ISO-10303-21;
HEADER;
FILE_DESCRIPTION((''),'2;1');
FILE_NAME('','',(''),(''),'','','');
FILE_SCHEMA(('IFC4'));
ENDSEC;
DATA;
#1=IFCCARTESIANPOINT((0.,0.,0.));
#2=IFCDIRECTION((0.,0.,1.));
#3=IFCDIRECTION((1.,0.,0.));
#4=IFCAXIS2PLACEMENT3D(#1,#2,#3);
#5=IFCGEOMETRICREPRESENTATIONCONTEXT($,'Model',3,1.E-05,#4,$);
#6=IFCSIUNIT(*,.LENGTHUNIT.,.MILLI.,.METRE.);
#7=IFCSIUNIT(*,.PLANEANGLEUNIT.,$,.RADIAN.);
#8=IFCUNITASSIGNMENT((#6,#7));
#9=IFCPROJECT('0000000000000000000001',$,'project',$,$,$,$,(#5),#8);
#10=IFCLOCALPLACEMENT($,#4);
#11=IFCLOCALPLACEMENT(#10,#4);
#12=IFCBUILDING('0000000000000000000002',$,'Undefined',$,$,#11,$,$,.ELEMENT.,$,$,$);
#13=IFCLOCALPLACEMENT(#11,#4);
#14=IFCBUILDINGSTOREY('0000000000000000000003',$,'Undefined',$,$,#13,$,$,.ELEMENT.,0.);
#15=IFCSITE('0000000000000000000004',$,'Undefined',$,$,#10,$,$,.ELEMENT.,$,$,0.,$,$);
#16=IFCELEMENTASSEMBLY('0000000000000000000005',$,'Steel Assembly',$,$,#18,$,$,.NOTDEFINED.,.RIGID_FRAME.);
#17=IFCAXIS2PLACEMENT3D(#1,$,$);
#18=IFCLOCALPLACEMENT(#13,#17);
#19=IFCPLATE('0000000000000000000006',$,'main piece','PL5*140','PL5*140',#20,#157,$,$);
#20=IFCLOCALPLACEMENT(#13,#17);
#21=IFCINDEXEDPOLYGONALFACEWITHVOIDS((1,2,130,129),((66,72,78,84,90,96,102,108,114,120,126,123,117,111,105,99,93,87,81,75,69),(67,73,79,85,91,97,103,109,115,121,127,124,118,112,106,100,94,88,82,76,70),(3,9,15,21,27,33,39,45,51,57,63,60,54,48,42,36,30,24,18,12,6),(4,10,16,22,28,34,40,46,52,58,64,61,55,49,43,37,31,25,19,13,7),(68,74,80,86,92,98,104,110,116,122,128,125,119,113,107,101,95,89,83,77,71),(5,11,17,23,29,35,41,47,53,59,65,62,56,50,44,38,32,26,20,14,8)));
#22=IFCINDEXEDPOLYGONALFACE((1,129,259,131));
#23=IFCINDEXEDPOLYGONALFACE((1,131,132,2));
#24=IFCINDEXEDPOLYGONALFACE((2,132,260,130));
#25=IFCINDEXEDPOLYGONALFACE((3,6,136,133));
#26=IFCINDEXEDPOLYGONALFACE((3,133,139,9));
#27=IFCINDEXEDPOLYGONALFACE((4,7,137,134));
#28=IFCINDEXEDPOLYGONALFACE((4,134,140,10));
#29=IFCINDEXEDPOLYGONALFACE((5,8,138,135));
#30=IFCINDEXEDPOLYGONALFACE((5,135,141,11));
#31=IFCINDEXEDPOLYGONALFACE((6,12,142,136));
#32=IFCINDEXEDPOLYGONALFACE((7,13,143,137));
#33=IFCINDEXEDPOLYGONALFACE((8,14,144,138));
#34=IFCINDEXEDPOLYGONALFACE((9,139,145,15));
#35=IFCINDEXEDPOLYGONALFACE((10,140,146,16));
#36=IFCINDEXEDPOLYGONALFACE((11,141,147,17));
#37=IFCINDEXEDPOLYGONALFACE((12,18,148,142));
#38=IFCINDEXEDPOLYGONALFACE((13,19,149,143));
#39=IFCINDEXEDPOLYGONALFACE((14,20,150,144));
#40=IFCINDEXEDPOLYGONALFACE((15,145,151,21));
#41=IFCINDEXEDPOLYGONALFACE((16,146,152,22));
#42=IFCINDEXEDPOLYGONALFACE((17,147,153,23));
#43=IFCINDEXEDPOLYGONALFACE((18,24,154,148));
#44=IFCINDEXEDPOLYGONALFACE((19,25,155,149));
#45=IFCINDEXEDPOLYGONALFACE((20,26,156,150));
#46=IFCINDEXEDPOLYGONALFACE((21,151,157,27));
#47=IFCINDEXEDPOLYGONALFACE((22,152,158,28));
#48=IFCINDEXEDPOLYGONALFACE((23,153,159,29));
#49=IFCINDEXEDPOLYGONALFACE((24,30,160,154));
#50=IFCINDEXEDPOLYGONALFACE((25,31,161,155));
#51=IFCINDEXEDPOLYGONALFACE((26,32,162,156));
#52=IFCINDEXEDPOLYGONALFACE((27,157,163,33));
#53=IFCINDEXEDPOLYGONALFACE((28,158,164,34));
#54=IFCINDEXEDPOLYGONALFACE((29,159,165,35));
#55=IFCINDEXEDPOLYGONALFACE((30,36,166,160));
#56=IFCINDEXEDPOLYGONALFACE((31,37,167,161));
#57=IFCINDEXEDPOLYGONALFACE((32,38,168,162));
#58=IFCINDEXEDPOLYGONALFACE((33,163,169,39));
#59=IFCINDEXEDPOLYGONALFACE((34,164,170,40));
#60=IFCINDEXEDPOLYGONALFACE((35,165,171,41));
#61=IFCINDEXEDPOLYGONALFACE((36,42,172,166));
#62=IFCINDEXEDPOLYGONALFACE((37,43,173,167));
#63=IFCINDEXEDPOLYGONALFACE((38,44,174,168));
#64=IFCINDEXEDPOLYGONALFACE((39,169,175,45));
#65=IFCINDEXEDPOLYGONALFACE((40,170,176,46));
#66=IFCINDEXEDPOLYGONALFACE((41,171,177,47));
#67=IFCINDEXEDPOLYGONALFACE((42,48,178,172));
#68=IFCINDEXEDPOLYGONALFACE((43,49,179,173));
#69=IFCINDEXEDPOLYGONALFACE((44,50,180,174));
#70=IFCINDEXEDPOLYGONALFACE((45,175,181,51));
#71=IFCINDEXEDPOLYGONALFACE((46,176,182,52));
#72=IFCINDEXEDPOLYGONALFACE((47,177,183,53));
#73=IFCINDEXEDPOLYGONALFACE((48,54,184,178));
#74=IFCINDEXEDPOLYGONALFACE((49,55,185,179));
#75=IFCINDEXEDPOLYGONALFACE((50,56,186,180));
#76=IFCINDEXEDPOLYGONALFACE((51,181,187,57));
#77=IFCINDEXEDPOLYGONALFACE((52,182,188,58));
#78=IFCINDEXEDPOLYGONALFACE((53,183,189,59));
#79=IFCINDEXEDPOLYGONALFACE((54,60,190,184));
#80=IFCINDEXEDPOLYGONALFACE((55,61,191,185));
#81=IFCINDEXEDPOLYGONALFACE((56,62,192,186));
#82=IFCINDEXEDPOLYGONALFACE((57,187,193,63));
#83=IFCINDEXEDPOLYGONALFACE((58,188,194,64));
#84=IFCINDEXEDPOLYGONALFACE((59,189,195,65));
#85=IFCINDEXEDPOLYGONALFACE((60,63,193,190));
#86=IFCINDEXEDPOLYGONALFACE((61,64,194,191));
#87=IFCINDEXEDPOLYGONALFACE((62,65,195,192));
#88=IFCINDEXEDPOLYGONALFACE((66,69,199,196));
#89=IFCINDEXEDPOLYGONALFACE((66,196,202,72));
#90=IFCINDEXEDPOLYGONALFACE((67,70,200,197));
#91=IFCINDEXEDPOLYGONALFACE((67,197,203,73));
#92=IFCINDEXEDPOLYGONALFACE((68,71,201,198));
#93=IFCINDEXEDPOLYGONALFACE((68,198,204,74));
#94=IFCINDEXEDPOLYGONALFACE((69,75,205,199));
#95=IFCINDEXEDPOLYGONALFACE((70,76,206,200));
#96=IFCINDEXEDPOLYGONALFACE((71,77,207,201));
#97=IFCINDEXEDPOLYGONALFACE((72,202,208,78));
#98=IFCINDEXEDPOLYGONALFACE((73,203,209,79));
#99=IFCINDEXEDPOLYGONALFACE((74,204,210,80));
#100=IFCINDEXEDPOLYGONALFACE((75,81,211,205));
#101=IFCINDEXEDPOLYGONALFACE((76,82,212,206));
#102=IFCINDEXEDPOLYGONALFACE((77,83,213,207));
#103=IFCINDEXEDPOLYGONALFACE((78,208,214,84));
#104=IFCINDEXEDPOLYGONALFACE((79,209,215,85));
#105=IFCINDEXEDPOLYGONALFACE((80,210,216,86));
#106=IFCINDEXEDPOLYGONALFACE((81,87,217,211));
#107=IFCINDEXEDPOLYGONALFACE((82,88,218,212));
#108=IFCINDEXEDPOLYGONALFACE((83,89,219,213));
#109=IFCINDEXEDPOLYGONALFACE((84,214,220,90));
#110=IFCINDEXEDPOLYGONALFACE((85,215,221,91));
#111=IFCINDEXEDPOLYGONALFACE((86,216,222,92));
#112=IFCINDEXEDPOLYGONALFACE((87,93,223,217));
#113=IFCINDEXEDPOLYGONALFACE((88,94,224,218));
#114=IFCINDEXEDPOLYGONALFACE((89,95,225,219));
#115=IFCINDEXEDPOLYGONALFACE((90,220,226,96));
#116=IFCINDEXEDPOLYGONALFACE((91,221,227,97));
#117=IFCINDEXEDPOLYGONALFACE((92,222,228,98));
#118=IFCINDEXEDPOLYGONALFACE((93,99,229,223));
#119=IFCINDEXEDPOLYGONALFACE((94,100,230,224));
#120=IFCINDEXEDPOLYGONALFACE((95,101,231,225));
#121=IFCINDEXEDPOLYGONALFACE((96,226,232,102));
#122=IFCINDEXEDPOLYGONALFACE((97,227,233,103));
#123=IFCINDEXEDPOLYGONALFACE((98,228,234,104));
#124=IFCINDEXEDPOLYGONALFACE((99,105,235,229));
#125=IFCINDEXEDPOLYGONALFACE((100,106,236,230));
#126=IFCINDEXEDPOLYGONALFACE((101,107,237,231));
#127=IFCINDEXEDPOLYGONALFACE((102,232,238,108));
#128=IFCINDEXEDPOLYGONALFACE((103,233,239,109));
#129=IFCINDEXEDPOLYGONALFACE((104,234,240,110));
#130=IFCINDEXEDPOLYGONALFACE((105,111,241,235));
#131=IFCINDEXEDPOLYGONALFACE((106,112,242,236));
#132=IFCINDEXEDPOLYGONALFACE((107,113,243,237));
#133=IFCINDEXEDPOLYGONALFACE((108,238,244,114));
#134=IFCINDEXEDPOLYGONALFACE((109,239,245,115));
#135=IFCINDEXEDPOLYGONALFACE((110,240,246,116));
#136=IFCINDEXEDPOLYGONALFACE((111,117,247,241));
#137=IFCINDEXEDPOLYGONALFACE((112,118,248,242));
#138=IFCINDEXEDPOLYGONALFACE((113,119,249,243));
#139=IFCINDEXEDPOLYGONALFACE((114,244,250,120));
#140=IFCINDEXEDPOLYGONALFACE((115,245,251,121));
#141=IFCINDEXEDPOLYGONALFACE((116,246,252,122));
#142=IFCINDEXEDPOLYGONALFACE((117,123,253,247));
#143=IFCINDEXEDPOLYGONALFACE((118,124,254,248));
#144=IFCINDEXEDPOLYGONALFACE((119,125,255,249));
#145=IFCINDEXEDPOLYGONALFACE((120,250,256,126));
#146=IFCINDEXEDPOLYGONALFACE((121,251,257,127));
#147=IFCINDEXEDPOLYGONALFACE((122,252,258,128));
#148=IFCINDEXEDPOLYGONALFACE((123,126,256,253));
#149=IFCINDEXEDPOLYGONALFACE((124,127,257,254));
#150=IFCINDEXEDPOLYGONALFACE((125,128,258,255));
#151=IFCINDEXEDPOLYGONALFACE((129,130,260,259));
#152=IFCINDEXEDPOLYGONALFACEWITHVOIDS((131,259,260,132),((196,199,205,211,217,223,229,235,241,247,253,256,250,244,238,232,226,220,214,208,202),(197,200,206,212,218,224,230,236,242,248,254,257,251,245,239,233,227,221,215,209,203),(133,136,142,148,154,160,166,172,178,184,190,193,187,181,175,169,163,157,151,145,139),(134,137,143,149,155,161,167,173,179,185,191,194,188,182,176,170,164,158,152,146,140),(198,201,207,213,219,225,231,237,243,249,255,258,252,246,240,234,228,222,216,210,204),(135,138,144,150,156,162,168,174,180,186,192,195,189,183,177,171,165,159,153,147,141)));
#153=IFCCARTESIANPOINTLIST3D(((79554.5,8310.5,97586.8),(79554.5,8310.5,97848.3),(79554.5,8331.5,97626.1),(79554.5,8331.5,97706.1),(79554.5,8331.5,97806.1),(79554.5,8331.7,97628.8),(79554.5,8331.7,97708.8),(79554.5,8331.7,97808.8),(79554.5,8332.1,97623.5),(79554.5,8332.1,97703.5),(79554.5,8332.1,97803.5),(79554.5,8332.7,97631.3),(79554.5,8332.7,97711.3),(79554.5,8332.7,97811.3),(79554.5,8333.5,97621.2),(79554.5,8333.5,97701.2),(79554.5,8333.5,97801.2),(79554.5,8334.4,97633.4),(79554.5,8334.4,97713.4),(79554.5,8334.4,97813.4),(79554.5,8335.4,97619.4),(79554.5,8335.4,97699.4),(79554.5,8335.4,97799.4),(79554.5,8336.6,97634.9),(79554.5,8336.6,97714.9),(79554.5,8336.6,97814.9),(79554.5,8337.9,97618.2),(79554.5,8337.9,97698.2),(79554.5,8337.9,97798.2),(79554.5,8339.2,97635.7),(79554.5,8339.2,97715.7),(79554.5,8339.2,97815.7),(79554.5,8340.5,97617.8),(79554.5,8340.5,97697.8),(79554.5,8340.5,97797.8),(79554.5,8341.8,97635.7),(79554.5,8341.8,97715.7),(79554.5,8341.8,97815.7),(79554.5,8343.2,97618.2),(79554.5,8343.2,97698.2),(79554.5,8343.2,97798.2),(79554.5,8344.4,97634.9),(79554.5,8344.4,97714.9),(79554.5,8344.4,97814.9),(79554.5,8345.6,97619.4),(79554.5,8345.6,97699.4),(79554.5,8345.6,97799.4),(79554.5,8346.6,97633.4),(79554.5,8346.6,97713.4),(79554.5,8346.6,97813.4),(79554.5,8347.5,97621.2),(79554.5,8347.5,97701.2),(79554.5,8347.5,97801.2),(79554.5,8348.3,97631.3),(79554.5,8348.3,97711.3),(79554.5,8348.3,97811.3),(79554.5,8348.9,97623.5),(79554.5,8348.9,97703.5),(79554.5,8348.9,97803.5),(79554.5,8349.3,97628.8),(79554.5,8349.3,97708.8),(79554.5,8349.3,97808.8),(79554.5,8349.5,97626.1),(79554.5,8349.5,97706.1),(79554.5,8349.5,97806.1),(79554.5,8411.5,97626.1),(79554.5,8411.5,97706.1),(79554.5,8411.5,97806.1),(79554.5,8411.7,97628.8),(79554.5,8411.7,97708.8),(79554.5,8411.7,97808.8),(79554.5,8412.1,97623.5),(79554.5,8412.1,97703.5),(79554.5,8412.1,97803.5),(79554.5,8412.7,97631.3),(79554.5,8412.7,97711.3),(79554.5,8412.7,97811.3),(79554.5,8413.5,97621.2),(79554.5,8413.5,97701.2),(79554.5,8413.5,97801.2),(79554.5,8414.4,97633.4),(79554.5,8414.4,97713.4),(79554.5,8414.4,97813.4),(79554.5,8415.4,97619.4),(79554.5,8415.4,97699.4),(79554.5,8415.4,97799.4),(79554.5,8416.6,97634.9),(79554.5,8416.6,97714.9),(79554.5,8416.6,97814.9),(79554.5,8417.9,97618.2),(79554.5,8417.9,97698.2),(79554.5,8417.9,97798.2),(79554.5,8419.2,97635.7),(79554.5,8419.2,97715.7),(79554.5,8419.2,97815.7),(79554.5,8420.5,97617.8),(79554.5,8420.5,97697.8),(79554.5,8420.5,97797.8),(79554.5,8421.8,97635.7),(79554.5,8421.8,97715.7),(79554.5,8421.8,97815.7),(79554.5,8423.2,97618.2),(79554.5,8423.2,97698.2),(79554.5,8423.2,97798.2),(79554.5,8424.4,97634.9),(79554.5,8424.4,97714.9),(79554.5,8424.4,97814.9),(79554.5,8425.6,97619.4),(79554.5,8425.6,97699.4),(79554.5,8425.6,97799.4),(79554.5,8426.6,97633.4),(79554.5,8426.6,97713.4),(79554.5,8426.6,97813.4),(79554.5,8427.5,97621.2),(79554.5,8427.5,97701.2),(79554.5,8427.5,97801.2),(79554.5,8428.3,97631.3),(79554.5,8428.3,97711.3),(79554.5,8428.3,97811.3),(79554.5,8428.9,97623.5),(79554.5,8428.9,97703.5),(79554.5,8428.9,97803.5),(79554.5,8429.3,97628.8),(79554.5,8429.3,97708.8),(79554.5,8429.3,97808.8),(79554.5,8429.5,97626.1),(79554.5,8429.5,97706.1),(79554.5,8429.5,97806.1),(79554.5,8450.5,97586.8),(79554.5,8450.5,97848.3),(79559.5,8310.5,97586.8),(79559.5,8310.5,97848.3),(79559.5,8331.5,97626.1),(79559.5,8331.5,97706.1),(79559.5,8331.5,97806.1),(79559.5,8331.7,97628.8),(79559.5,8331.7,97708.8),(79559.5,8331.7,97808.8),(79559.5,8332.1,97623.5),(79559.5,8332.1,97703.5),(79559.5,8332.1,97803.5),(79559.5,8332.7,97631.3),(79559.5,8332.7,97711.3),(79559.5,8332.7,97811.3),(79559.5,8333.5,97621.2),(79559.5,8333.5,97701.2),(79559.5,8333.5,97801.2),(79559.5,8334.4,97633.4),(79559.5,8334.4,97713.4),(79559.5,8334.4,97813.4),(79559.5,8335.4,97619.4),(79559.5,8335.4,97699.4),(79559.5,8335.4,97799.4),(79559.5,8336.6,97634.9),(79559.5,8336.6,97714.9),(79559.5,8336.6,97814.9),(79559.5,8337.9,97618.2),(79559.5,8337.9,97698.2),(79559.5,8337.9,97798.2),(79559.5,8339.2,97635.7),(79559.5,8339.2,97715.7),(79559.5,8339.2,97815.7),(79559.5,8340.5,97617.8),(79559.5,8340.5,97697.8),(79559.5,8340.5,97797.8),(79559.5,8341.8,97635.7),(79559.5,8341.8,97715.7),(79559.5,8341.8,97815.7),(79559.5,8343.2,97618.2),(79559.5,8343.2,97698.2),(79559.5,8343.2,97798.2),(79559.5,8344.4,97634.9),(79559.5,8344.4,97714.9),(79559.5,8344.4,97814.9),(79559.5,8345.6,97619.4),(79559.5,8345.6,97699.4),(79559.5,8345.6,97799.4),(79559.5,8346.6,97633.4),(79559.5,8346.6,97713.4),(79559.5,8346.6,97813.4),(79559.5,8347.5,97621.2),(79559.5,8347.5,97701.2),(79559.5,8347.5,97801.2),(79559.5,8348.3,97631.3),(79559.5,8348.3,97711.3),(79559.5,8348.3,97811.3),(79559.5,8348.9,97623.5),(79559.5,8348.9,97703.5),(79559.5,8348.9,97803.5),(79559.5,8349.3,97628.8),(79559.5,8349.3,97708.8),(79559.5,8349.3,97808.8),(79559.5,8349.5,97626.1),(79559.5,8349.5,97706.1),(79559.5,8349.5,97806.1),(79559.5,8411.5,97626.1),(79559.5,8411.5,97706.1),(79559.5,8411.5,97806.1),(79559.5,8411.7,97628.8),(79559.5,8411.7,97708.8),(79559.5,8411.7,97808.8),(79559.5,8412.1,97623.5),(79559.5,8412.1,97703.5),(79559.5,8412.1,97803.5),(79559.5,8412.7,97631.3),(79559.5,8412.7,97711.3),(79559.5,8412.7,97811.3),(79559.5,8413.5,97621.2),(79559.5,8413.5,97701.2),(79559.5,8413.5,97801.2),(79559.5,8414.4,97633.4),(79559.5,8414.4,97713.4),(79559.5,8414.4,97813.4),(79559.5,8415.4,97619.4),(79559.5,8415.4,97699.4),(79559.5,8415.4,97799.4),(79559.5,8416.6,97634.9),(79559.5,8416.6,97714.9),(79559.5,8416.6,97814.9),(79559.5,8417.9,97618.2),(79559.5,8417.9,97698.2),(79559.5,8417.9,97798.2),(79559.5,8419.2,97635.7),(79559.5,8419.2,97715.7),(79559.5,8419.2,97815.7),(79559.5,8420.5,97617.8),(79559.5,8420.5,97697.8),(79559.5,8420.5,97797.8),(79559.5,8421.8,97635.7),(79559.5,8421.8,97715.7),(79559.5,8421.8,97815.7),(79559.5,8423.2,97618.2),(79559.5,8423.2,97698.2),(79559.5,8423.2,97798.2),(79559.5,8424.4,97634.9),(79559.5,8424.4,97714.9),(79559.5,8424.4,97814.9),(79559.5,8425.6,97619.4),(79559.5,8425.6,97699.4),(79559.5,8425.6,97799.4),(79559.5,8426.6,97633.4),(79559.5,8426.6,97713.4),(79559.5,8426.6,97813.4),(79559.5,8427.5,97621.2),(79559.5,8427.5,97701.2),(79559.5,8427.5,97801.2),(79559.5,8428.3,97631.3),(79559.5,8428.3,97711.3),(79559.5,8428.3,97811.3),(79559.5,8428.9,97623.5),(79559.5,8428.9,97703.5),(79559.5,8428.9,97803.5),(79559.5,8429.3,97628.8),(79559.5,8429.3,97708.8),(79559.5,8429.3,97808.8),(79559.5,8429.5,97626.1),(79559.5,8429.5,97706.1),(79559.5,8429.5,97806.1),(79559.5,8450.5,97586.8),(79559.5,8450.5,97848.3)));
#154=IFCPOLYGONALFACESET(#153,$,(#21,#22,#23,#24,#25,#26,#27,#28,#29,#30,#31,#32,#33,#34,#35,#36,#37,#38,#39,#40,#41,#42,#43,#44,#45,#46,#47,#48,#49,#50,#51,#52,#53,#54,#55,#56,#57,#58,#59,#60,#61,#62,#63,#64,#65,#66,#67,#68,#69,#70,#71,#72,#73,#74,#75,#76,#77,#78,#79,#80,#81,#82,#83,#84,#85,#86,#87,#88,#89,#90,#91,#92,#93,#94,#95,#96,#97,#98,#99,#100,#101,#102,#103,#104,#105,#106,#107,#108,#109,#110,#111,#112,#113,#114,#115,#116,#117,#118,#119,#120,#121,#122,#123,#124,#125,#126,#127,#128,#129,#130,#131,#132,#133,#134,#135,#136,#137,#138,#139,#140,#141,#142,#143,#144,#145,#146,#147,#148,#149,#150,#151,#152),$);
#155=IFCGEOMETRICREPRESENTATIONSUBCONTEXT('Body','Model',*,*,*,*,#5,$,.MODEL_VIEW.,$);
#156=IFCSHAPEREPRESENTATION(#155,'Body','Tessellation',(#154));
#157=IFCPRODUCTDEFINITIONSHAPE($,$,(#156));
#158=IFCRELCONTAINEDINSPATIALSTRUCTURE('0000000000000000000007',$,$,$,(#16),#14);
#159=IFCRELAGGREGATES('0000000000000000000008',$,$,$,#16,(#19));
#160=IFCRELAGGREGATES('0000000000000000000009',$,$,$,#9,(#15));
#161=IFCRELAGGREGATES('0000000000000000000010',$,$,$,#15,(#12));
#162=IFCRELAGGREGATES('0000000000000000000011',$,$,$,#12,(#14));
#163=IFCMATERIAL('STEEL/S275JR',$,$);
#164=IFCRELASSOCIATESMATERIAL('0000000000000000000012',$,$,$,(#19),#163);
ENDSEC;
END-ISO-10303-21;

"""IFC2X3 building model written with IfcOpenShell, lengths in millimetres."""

from ifc_helpers import new_model, si_unit, frame, origin_with_axes, origin_2d_with_axis, place, context, subcontext, project, spatial, polyline, circle, outline, extrude, source, transform, mapped, material, element, aggregate, save


model = new_model("IFC2X3")

# Units and contexts
model_context = context("Model", 3, precision=1e-05, world=origin_with_axes())
body_context = subcontext(model_context, "Body", "Model", "MODEL_VIEW")
ifc_project = project(units=[si_unit("LENGTHUNIT", "METRE", prefix="MILLI"), si_unit("PLANEANGLEUNIT", "RADIAN")], contexts=[model_context])

# Site, building, storey
site_placement = place(None, origin_with_axes())
site = spatial("IfcSite", under=ifc_project, at=site_placement, Name="Undefined", CompositionType="ELEMENT", RefElevation=0.0)
building_placement = place(site_placement, origin_with_axes())
building = spatial("IfcBuilding", under=site, at=building_placement, Name="Undefined", CompositionType="ELEMENT")
storey_placement = place(building_placement, origin_with_axes())
storey = spatial("IfcBuildingStorey", under=building, at=storey_placement, Name="Undefined", CompositionType="ELEMENT", Elevation=0.0)

# Element assembly, plate, opening
ifc_material_1 = material(Name="STEEL/S275JR")
assembly_1_placement = place(storey_placement, origin_with_axes())
assembly_1 = element("IfcElementAssembly", 1, at=assembly_1_placement, inside=storey, Name="Steel Assembly", AssemblyPlace="NOTDEFINED", PredefinedType="RIGID_FRAME")
plate_1_placement = place(assembly_1_placement, frame((79557.0, 8450.5, 97848.3), z_axis=(1.0, 0.0, 0.0), x_axis=(0.0, -1.0, 0.0)))
plate_1 = element("IfcPlate", 2, at=plate_1_placement, material=ifc_material_1, Name="main piece", Description="PL5*140", ObjectType="PL5*140", context=body_context, shape_type="SweptSolid", body=[
    extrude(outline(polyline([(0.0, 0.0), (140.0, 0.0), (140.0, 261.5), (0.0, 261.5), (0.0, 0.0)])), frame((0.0, 0.0, -2.5), z_axis=(0.0, 0.0, 1.0), x_axis=(1.0, 0.0, 0.0)), (0.0, 0.0, 1.0), 5.0),
])
shared_shape_1 = source(origin_with_axes(), body_context, "Body", "SweptSolid", [
    extrude(circle(Radius=9.0, at=origin_2d_with_axis()), frame((0.0, -5.1, 0.0), z_axis=(0.0, 1.0, 0.0), x_axis=(1.0, 0.0, 0.0)), (0.0, 0.0, 1.0), 10.3),
])
opening_1_placement = place(assembly_1_placement, frame((79559.5, 8380.5, 97806.8), z_axis=(0.0, -1.0, 0.0), x_axis=(0.0, 0.0, -1.0)))
element("IfcOpeningElement", 3, at=opening_1_placement, cuts=plate_1, ObjectType="Opening", context=body_context, shape_type="MappedRepresentation", body=[
    mapped(shared_shape_1, transform((0.0, 0.0, -40.0))),
    mapped(shared_shape_1, transform((100.0, 0.0, -40.0))),
    mapped(shared_shape_1, transform((180.0, 0.0, -40.0))),
    mapped(shared_shape_1, transform((0.0, 0.0, 40.0))),
    mapped(shared_shape_1, transform((100.0, 0.0, 40.0))),
    mapped(shared_shape_1, transform((180.0, 0.0, 40.0))),
])

aggregate(assembly_1, [plate_1])

save(model, "model.ifc")
